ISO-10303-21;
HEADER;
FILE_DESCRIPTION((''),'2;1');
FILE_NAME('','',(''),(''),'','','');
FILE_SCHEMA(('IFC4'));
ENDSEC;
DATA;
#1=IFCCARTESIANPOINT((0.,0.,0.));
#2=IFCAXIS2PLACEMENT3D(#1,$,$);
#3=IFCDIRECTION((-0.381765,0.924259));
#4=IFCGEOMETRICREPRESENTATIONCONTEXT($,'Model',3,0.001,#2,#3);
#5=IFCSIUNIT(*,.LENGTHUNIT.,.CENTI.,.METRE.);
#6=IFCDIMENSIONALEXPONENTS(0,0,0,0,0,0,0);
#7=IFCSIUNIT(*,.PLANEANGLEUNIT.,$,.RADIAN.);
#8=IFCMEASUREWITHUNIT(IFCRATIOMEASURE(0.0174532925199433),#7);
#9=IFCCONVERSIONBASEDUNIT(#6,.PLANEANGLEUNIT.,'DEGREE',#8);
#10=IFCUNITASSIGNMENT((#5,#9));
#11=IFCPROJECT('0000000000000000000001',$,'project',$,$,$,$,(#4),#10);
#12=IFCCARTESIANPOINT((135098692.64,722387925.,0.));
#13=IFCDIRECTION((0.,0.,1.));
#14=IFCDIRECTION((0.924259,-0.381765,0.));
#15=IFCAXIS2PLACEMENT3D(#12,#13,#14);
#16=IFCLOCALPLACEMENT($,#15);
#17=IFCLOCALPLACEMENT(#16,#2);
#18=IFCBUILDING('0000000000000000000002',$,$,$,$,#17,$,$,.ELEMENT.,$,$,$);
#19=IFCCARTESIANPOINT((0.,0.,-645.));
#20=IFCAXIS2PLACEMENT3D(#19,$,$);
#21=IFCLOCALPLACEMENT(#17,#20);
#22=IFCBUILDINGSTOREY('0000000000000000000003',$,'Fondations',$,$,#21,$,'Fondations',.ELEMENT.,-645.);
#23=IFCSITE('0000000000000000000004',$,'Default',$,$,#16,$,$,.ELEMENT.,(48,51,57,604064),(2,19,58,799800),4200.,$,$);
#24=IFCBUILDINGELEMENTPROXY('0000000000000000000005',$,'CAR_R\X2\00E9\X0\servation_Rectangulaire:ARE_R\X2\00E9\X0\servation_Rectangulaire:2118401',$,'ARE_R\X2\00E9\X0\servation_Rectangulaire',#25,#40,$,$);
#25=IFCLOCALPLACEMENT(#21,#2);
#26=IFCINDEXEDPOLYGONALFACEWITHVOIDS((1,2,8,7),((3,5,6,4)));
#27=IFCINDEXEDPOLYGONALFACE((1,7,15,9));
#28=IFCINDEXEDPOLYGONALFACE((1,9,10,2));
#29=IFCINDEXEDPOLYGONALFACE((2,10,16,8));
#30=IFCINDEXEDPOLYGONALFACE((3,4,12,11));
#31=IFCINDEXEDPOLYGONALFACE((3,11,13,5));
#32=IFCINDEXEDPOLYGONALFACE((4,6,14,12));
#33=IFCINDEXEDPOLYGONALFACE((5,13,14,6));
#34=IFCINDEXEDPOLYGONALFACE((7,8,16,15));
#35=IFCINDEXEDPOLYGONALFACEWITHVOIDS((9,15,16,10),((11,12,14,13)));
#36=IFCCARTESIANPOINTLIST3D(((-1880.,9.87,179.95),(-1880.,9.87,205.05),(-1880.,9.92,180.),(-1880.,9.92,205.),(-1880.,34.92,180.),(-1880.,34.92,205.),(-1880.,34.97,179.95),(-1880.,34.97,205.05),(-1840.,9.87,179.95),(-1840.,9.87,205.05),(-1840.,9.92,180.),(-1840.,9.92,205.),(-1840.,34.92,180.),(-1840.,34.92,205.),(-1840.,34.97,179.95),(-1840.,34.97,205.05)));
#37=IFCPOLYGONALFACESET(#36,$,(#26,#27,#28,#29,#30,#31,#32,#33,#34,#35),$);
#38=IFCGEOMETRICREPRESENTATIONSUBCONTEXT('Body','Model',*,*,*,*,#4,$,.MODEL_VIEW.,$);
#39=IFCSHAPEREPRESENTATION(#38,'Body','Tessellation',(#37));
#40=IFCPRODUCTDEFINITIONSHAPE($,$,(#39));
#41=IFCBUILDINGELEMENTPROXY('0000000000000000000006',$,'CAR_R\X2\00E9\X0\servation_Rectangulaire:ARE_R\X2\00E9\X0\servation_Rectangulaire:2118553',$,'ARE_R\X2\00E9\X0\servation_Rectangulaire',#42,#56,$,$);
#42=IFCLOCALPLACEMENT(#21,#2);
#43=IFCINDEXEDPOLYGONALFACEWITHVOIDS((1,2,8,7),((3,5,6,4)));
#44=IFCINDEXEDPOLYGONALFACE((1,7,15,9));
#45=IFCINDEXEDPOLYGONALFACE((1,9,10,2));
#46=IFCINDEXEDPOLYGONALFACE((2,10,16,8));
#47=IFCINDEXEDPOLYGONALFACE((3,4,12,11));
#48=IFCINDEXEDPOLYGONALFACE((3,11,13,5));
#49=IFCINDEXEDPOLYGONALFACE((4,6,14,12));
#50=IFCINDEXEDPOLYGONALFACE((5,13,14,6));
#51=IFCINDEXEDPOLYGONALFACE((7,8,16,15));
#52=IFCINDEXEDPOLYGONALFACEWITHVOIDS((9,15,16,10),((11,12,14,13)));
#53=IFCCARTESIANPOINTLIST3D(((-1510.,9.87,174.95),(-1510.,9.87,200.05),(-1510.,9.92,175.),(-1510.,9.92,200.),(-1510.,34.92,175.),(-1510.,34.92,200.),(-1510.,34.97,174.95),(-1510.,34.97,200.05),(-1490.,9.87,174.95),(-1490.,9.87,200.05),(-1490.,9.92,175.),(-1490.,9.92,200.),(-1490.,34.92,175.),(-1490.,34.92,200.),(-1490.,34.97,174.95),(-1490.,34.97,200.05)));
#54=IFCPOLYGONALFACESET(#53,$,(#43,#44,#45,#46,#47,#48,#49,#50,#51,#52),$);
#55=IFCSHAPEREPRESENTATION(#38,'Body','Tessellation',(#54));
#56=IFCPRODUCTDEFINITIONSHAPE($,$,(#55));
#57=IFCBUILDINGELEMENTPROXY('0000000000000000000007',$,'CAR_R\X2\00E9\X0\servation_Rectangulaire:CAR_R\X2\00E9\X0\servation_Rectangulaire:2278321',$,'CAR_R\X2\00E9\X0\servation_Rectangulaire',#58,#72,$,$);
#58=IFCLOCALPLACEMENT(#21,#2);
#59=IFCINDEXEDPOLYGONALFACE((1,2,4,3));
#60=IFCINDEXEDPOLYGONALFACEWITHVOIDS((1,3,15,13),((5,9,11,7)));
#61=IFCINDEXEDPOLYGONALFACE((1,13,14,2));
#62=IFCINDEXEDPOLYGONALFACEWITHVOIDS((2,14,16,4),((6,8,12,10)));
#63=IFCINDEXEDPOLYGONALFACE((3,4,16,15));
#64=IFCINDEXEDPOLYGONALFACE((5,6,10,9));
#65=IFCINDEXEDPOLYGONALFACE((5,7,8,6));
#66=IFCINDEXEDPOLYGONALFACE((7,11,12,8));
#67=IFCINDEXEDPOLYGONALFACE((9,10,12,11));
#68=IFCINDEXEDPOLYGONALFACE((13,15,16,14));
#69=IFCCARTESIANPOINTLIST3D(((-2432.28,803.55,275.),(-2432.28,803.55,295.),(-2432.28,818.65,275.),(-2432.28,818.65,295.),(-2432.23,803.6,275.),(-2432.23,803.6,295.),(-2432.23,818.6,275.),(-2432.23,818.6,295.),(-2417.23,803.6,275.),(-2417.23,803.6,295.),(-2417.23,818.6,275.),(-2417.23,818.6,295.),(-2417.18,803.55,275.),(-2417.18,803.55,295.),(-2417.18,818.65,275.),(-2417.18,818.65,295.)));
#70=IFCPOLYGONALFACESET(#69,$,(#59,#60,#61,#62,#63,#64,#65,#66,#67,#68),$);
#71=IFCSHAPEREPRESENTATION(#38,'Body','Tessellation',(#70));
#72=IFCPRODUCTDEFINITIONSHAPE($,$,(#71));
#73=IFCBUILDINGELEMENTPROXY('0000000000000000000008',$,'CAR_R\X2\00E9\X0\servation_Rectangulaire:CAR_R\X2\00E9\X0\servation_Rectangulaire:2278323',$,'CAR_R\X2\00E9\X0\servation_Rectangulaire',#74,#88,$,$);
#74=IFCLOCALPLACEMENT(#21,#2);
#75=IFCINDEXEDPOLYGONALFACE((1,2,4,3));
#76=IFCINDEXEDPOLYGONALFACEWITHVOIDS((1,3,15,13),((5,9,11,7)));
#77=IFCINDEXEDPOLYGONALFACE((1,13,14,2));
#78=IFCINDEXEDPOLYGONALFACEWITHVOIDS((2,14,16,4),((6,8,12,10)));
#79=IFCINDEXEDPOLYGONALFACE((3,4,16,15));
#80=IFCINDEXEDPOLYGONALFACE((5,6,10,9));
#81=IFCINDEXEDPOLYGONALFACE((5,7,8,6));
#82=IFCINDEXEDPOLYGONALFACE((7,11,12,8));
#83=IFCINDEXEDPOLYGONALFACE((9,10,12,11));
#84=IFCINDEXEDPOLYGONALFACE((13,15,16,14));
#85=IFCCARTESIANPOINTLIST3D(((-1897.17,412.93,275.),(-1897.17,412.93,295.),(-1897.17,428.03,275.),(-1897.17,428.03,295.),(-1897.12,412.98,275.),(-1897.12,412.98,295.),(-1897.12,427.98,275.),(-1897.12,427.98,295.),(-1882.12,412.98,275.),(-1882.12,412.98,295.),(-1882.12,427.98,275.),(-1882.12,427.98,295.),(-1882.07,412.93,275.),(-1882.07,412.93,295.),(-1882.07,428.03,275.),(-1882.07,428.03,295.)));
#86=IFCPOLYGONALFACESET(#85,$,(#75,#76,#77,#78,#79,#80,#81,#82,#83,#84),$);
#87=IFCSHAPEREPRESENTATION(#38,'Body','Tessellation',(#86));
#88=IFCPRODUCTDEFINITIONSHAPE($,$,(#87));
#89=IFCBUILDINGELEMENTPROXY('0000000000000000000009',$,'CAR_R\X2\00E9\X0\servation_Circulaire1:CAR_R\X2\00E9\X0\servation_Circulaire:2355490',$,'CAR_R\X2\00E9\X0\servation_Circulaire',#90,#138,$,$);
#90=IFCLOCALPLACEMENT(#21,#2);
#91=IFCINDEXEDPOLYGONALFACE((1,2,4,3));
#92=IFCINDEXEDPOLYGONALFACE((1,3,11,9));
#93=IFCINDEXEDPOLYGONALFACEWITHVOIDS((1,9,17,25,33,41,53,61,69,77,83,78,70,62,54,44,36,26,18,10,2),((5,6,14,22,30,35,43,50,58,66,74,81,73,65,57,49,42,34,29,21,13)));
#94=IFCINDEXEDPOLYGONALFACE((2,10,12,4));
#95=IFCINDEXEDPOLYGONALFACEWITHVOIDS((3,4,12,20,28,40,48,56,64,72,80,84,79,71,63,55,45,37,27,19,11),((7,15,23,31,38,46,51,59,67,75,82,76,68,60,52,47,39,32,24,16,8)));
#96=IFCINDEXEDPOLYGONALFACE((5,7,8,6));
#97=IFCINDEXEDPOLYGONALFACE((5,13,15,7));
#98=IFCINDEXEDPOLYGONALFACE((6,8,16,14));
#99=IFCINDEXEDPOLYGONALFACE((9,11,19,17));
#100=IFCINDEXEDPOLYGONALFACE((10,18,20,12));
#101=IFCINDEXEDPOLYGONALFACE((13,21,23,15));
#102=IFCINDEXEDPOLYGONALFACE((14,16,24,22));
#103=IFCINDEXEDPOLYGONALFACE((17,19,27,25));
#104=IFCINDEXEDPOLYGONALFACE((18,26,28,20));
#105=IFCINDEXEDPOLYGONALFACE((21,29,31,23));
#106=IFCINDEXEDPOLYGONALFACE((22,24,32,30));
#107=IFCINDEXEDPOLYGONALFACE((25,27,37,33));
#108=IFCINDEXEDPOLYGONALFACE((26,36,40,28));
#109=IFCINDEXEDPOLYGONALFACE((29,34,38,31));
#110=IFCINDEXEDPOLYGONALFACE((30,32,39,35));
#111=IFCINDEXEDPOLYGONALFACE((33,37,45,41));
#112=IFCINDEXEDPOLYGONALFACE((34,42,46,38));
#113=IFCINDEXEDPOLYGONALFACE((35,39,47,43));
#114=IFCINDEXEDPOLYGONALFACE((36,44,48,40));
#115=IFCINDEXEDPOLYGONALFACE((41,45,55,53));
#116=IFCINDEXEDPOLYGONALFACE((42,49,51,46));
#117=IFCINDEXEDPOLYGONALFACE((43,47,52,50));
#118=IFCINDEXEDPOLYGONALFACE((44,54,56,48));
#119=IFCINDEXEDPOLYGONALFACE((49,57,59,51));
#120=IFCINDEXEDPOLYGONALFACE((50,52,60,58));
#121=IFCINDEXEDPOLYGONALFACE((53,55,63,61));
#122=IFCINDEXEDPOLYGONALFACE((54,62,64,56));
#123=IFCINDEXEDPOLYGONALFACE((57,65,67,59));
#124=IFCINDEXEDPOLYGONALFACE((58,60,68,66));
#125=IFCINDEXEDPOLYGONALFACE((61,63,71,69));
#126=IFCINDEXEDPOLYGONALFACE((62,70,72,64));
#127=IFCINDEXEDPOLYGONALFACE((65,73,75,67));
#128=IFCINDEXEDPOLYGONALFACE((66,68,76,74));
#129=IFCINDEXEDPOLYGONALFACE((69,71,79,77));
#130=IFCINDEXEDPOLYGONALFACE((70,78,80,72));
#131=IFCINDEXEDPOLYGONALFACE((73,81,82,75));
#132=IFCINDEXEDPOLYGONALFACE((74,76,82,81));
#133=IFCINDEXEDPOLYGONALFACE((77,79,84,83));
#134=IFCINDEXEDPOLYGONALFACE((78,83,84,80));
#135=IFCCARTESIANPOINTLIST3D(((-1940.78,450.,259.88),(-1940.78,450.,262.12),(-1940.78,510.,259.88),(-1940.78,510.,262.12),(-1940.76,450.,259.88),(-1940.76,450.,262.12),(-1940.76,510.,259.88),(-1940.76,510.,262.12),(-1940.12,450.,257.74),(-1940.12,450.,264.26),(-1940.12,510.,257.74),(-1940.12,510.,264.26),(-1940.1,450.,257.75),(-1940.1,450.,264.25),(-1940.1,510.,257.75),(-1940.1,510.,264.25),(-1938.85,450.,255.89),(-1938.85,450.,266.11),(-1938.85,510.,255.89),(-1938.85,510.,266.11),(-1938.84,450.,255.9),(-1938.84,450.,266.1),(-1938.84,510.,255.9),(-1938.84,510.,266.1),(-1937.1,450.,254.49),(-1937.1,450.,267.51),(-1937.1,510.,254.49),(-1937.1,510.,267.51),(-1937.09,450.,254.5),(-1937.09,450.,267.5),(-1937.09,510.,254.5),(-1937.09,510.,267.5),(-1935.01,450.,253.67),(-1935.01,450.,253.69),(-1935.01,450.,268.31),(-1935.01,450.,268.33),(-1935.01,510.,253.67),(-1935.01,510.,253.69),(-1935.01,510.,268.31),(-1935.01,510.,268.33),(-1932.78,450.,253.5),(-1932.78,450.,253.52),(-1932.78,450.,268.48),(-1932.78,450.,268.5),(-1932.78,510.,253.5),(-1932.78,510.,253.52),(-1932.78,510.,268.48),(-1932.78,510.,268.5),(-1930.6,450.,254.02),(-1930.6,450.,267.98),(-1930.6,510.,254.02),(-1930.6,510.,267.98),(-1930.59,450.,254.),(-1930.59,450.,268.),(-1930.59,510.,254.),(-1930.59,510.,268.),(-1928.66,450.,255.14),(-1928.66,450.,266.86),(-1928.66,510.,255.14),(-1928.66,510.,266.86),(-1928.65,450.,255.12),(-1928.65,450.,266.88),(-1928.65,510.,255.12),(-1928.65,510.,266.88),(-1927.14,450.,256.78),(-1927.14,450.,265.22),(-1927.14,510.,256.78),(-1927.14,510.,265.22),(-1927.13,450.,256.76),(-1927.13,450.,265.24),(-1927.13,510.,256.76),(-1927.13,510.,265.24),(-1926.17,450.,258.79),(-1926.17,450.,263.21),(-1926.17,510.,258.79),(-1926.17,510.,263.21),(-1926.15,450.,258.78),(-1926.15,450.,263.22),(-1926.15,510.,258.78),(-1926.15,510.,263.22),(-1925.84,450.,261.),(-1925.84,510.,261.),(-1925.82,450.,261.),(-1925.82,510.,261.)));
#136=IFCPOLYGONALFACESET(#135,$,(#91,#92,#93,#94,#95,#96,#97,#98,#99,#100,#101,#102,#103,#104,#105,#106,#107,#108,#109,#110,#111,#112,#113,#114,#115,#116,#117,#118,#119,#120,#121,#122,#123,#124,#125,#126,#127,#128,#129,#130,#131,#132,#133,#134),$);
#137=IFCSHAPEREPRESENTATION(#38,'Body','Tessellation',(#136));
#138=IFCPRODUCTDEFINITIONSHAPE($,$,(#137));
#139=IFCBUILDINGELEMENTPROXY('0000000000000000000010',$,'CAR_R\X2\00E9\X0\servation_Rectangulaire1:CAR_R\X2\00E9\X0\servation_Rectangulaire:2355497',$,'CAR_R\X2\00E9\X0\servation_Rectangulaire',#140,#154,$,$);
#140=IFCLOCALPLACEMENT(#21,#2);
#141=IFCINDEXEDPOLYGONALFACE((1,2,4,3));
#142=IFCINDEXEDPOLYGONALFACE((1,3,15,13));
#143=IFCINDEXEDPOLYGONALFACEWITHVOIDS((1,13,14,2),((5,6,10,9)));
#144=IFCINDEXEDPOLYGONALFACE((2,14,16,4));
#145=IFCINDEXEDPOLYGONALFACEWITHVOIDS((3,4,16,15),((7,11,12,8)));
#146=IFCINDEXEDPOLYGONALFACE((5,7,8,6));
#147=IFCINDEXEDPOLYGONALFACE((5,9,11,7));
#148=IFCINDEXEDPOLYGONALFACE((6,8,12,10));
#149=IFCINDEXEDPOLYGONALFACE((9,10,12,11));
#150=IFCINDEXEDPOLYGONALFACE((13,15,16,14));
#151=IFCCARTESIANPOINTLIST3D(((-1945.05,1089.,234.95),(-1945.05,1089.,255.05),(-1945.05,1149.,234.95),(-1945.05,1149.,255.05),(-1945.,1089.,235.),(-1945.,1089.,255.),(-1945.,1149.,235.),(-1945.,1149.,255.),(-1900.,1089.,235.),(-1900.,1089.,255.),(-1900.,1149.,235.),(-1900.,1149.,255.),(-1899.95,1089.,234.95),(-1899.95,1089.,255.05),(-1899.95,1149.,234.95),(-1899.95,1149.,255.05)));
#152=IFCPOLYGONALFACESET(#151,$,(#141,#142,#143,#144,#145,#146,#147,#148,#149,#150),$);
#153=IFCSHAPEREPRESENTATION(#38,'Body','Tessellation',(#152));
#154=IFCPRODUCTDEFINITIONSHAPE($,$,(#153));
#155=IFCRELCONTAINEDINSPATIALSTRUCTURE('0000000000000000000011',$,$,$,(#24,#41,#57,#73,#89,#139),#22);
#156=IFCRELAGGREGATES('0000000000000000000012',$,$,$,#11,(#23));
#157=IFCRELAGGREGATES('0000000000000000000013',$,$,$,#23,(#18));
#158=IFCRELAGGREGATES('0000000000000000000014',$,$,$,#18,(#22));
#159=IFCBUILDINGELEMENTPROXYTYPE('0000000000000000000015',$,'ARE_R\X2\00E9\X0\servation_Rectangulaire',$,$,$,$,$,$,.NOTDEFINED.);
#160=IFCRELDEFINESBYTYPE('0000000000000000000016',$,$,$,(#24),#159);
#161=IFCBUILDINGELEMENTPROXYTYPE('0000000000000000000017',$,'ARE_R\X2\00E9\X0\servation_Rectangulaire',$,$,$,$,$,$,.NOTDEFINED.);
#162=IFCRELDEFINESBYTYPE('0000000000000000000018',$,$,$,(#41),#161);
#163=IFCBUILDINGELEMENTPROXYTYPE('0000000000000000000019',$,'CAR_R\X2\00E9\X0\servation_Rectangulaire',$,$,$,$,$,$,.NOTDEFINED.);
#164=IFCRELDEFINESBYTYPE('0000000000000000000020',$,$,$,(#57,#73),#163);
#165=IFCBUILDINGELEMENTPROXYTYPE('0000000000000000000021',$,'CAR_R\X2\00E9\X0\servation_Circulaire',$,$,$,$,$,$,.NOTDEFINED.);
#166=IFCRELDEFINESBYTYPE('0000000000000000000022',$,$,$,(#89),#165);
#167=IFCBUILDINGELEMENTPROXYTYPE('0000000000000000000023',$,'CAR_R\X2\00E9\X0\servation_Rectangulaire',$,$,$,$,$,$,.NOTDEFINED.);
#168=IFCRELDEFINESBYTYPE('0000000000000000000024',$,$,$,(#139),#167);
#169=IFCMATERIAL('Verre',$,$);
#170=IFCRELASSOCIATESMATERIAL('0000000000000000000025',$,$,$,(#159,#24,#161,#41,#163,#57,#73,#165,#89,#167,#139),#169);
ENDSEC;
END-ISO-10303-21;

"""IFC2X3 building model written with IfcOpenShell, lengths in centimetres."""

from ifc_helpers import new_model, entity, si_unit, converted_unit, direction, frame, frame_2d, origin, place, context, subcontext, project, spatial, polyline, hollow_circle, outline, extrude, source, transform, mapped, material, type_object, type_shapes, element, save


model = new_model("IFC2X3")

# Units and contexts
model_context = context("Model", 3, precision=0.001, world=origin(), true_north=direction((-0.381765, 0.924259)))
body_context = subcontext(model_context, "Body", "Model", "MODEL_VIEW")
ifc_project = project(units=[si_unit("LENGTHUNIT", "METRE", prefix="CENTI"), converted_unit("PLANEANGLEUNIT", "DEGREE", entity("IfcRatioMeasure", 0.0174532925199433), si_unit("PLANEANGLEUNIT", "RADIAN"), dimensions=[0, 0, 0, 0, 0, 0, 0])], contexts=[model_context])

# Site, building, storey
site_placement = place(None, frame((135098692.64, 722387925.0, 0.0), z_axis=(0.0, 0.0, 1.0), x_axis=(0.924259, -0.381765, 0.0)))
site = spatial("IfcSite", under=ifc_project, at=site_placement, Name="Default", CompositionType="ELEMENT", RefLatitude=(48, 51, 57, 604064), RefLongitude=(2, 19, 58, 799800), RefElevation=4200.0)
building_placement = place(site_placement, origin())
building = spatial("IfcBuilding", under=site, at=building_placement, CompositionType="ELEMENT")
storey_placement = place(building_placement, frame((0.0, 0.0, -645.0)))
storey = spatial("IfcBuildingStorey", under=building, at=storey_placement, Name="Fondations", LongName="Fondations", CompositionType="ELEMENT", Elevation=-645.0)

# Building element proxies
ifc_material_1 = material(Name="Verre")
building_element_proxy_type_1 = type_object("IfcBuildingElementProxyType", Name="ARE_Réservation_Rectangulaire", PredefinedType="NOTDEFINED", material=ifc_material_1)
shared_shape_1 = source(origin(), body_context, "Body", "SweptSolid", [
    extrude(outline(polyline([(-12.55, -12.55), (12.55, -12.55), (12.55, 12.55), (-12.55, 12.55), (-12.55, -12.55)]), holes=[polyline([(12.5, -12.5), (-12.5, -12.5), (-12.5, 12.5), (12.5, 12.5), (12.5, -12.5)])]), frame((0.0, 0.0, -40.0), z_axis=(0.0, 0.0, 1.0), x_axis=(-1.0, 0.0, 0.0)), (0.0, 0.0, 1.0), 40.0),
])
type_shapes(building_element_proxy_type_1, [shared_shape_1])
proxy_1_placement = place(storey_placement, frame((-1840.0, 22.42, 192.5), z_axis=(1.0, 0.0, 0.0), x_axis=(0.0, 1.0, 0.0)))
element("IfcBuildingElementProxy", 1, at=proxy_1_placement, inside=storey, type_object=building_element_proxy_type_1, material=ifc_material_1, Name="CAR_Réservation_Rectangulaire:ARE_Réservation_Rectangulaire:2118401", ObjectType="ARE_Réservation_Rectangulaire", context=body_context, shape_type="MappedRepresentation", body=[
    mapped(shared_shape_1, transform((0.0, 0.0, 0.0), scale=1.0)),
])
building_element_proxy_type_2 = type_object("IfcBuildingElementProxyType", Name="ARE_Réservation_Rectangulaire", PredefinedType="NOTDEFINED", material=ifc_material_1)
shared_shape_2 = source(origin(), body_context, "Body", "SweptSolid", [
    extrude(outline(polyline([(-12.55, -12.55), (12.55, -12.55), (12.55, 12.55), (-12.55, 12.55), (-12.55, -12.55)]), holes=[polyline([(12.5, -12.5), (-12.5, -12.5), (-12.5, 12.5), (12.5, 12.5), (12.5, -12.5)])]), frame((0.0, 0.0, -20.0), z_axis=(0.0, 0.0, 1.0), x_axis=(-1.0, 0.0, 0.0)), (0.0, 0.0, 1.0), 20.0),
])
type_shapes(building_element_proxy_type_2, [shared_shape_2])
proxy_2_placement = place(storey_placement, frame((-1490.0, 22.42, 187.5), z_axis=(1.0, 0.0, 0.0), x_axis=(0.0, 1.0, 0.0)))
element("IfcBuildingElementProxy", 2, at=proxy_2_placement, inside=storey, type_object=building_element_proxy_type_2, material=ifc_material_1, Name="CAR_Réservation_Rectangulaire:ARE_Réservation_Rectangulaire:2118553", ObjectType="ARE_Réservation_Rectangulaire", context=body_context, shape_type="MappedRepresentation", body=[
    mapped(shared_shape_2, transform((0.0, 0.0, 0.0), scale=1.0)),
])
building_element_proxy_type_3 = type_object("IfcBuildingElementProxyType", Name="CAR_Réservation_Rectangulaire", PredefinedType="NOTDEFINED", material=ifc_material_1)
shared_shape_3 = source(origin(), body_context, "Body", "SweptSolid", [
    extrude(outline(polyline([(-7.55, -7.55), (7.55, -7.55), (7.55, 7.55), (-7.55, 7.55), (-7.55, -7.55)]), holes=[polyline([(7.5, -7.5), (-7.5, -7.5), (-7.5, 7.5), (7.5, 7.5), (7.5, -7.5)])]), frame((0.0, 0.0, -20.0), z_axis=(0.0, 0.0, 1.0), x_axis=(-1.0, 0.0, 0.0)), (0.0, 0.0, 1.0), 20.0),
])
type_shapes(building_element_proxy_type_3, [shared_shape_3])
for number, where, z_axis, x_axis, name in (
    (3, (-2424.73, 811.1, 295.0), (0.0, 0.0, 1.0), (0.0, 1.0, 0.0), "CAR_Réservation_Rectangulaire:CAR_Réservation_Rectangulaire:2278321"),
    (4, (-1889.62, 420.48, 295.0), (0.0, 0.0, 1.0), (0.0, 1.0, 0.0), "CAR_Réservation_Rectangulaire:CAR_Réservation_Rectangulaire:2278323"),
):
    element("IfcBuildingElementProxy", number, at=place(storey_placement, frame(where, z_axis=z_axis, x_axis=x_axis)), inside=storey, type_object=building_element_proxy_type_3, material=ifc_material_1, Name=name, ObjectType="CAR_Réservation_Rectangulaire", context=body_context, shape_type="MappedRepresentation", body=[
        mapped(shared_shape_3, transform((0.0, 0.0, 0.0), scale=1.0)),
    ])
building_element_proxy_type_4 = type_object("IfcBuildingElementProxyType", Name="CAR_Réservation_Circulaire", PredefinedType="NOTDEFINED", material=ifc_material_1)
shared_shape_4 = source(origin(), body_context, "Body", "SweptSolid", [
    extrude(hollow_circle(Radius=7.52, WallThickness=0.02, at=frame_2d((0.0, 0.0), x_axis=(1.0, 0.0))), frame((0.0, 0.0, -60.0)), (0.0, 0.0, 1.0), 60.0),
])
type_shapes(building_element_proxy_type_4, [shared_shape_4])
proxy_3_placement = place(storey_placement, frame((-1933.34, 510.0, 261.0), z_axis=(0.0, 1.0, 0.0), x_axis=(1.0, 0.0, 0.0)))
element("IfcBuildingElementProxy", 5, at=proxy_3_placement, inside=storey, type_object=building_element_proxy_type_4, material=ifc_material_1, Name="CAR_Réservation_Circulaire1:CAR_Réservation_Circulaire:2355490", ObjectType="CAR_Réservation_Circulaire", context=body_context, shape_type="MappedRepresentation", body=[
    mapped(shared_shape_4, transform((0.0, 0.0, 0.0), scale=1.0)),
])
building_element_proxy_type_5 = type_object("IfcBuildingElementProxyType", Name="CAR_Réservation_Rectangulaire", PredefinedType="NOTDEFINED", material=ifc_material_1)
shared_shape_5 = source(origin(), body_context, "Body", "SweptSolid", [
    extrude(outline(polyline([(-22.55, -10.05), (22.55, -10.05), (22.55, 10.05), (-22.55, 10.05), (-22.55, -10.05)]), holes=[polyline([(22.5, -10.0), (-22.5, -10.0), (-22.5, 10.0), (22.5, 10.0), (22.5, -10.0)])]), frame((0.0, 0.0, -60.0), z_axis=(0.0, 0.0, 1.0), x_axis=(-1.0, 0.0, 0.0)), (0.0, 0.0, 1.0), 60.0),
])
type_shapes(building_element_proxy_type_5, [shared_shape_5])
proxy_4_placement = place(storey_placement, frame((-1922.5, 1089.0, 245.0), z_axis=(0.0, -1.0, 0.0), x_axis=(1.0, 0.0, 0.0)))
element("IfcBuildingElementProxy", 6, at=proxy_4_placement, inside=storey, type_object=building_element_proxy_type_5, material=ifc_material_1, Name="CAR_Réservation_Rectangulaire1:CAR_Réservation_Rectangulaire:2355497", ObjectType="CAR_Réservation_Rectangulaire", context=body_context, shape_type="MappedRepresentation", body=[
    mapped(shared_shape_5, transform((0.0, 0.0, 0.0), scale=1.0)),
])

save(model, "model.ifc")
